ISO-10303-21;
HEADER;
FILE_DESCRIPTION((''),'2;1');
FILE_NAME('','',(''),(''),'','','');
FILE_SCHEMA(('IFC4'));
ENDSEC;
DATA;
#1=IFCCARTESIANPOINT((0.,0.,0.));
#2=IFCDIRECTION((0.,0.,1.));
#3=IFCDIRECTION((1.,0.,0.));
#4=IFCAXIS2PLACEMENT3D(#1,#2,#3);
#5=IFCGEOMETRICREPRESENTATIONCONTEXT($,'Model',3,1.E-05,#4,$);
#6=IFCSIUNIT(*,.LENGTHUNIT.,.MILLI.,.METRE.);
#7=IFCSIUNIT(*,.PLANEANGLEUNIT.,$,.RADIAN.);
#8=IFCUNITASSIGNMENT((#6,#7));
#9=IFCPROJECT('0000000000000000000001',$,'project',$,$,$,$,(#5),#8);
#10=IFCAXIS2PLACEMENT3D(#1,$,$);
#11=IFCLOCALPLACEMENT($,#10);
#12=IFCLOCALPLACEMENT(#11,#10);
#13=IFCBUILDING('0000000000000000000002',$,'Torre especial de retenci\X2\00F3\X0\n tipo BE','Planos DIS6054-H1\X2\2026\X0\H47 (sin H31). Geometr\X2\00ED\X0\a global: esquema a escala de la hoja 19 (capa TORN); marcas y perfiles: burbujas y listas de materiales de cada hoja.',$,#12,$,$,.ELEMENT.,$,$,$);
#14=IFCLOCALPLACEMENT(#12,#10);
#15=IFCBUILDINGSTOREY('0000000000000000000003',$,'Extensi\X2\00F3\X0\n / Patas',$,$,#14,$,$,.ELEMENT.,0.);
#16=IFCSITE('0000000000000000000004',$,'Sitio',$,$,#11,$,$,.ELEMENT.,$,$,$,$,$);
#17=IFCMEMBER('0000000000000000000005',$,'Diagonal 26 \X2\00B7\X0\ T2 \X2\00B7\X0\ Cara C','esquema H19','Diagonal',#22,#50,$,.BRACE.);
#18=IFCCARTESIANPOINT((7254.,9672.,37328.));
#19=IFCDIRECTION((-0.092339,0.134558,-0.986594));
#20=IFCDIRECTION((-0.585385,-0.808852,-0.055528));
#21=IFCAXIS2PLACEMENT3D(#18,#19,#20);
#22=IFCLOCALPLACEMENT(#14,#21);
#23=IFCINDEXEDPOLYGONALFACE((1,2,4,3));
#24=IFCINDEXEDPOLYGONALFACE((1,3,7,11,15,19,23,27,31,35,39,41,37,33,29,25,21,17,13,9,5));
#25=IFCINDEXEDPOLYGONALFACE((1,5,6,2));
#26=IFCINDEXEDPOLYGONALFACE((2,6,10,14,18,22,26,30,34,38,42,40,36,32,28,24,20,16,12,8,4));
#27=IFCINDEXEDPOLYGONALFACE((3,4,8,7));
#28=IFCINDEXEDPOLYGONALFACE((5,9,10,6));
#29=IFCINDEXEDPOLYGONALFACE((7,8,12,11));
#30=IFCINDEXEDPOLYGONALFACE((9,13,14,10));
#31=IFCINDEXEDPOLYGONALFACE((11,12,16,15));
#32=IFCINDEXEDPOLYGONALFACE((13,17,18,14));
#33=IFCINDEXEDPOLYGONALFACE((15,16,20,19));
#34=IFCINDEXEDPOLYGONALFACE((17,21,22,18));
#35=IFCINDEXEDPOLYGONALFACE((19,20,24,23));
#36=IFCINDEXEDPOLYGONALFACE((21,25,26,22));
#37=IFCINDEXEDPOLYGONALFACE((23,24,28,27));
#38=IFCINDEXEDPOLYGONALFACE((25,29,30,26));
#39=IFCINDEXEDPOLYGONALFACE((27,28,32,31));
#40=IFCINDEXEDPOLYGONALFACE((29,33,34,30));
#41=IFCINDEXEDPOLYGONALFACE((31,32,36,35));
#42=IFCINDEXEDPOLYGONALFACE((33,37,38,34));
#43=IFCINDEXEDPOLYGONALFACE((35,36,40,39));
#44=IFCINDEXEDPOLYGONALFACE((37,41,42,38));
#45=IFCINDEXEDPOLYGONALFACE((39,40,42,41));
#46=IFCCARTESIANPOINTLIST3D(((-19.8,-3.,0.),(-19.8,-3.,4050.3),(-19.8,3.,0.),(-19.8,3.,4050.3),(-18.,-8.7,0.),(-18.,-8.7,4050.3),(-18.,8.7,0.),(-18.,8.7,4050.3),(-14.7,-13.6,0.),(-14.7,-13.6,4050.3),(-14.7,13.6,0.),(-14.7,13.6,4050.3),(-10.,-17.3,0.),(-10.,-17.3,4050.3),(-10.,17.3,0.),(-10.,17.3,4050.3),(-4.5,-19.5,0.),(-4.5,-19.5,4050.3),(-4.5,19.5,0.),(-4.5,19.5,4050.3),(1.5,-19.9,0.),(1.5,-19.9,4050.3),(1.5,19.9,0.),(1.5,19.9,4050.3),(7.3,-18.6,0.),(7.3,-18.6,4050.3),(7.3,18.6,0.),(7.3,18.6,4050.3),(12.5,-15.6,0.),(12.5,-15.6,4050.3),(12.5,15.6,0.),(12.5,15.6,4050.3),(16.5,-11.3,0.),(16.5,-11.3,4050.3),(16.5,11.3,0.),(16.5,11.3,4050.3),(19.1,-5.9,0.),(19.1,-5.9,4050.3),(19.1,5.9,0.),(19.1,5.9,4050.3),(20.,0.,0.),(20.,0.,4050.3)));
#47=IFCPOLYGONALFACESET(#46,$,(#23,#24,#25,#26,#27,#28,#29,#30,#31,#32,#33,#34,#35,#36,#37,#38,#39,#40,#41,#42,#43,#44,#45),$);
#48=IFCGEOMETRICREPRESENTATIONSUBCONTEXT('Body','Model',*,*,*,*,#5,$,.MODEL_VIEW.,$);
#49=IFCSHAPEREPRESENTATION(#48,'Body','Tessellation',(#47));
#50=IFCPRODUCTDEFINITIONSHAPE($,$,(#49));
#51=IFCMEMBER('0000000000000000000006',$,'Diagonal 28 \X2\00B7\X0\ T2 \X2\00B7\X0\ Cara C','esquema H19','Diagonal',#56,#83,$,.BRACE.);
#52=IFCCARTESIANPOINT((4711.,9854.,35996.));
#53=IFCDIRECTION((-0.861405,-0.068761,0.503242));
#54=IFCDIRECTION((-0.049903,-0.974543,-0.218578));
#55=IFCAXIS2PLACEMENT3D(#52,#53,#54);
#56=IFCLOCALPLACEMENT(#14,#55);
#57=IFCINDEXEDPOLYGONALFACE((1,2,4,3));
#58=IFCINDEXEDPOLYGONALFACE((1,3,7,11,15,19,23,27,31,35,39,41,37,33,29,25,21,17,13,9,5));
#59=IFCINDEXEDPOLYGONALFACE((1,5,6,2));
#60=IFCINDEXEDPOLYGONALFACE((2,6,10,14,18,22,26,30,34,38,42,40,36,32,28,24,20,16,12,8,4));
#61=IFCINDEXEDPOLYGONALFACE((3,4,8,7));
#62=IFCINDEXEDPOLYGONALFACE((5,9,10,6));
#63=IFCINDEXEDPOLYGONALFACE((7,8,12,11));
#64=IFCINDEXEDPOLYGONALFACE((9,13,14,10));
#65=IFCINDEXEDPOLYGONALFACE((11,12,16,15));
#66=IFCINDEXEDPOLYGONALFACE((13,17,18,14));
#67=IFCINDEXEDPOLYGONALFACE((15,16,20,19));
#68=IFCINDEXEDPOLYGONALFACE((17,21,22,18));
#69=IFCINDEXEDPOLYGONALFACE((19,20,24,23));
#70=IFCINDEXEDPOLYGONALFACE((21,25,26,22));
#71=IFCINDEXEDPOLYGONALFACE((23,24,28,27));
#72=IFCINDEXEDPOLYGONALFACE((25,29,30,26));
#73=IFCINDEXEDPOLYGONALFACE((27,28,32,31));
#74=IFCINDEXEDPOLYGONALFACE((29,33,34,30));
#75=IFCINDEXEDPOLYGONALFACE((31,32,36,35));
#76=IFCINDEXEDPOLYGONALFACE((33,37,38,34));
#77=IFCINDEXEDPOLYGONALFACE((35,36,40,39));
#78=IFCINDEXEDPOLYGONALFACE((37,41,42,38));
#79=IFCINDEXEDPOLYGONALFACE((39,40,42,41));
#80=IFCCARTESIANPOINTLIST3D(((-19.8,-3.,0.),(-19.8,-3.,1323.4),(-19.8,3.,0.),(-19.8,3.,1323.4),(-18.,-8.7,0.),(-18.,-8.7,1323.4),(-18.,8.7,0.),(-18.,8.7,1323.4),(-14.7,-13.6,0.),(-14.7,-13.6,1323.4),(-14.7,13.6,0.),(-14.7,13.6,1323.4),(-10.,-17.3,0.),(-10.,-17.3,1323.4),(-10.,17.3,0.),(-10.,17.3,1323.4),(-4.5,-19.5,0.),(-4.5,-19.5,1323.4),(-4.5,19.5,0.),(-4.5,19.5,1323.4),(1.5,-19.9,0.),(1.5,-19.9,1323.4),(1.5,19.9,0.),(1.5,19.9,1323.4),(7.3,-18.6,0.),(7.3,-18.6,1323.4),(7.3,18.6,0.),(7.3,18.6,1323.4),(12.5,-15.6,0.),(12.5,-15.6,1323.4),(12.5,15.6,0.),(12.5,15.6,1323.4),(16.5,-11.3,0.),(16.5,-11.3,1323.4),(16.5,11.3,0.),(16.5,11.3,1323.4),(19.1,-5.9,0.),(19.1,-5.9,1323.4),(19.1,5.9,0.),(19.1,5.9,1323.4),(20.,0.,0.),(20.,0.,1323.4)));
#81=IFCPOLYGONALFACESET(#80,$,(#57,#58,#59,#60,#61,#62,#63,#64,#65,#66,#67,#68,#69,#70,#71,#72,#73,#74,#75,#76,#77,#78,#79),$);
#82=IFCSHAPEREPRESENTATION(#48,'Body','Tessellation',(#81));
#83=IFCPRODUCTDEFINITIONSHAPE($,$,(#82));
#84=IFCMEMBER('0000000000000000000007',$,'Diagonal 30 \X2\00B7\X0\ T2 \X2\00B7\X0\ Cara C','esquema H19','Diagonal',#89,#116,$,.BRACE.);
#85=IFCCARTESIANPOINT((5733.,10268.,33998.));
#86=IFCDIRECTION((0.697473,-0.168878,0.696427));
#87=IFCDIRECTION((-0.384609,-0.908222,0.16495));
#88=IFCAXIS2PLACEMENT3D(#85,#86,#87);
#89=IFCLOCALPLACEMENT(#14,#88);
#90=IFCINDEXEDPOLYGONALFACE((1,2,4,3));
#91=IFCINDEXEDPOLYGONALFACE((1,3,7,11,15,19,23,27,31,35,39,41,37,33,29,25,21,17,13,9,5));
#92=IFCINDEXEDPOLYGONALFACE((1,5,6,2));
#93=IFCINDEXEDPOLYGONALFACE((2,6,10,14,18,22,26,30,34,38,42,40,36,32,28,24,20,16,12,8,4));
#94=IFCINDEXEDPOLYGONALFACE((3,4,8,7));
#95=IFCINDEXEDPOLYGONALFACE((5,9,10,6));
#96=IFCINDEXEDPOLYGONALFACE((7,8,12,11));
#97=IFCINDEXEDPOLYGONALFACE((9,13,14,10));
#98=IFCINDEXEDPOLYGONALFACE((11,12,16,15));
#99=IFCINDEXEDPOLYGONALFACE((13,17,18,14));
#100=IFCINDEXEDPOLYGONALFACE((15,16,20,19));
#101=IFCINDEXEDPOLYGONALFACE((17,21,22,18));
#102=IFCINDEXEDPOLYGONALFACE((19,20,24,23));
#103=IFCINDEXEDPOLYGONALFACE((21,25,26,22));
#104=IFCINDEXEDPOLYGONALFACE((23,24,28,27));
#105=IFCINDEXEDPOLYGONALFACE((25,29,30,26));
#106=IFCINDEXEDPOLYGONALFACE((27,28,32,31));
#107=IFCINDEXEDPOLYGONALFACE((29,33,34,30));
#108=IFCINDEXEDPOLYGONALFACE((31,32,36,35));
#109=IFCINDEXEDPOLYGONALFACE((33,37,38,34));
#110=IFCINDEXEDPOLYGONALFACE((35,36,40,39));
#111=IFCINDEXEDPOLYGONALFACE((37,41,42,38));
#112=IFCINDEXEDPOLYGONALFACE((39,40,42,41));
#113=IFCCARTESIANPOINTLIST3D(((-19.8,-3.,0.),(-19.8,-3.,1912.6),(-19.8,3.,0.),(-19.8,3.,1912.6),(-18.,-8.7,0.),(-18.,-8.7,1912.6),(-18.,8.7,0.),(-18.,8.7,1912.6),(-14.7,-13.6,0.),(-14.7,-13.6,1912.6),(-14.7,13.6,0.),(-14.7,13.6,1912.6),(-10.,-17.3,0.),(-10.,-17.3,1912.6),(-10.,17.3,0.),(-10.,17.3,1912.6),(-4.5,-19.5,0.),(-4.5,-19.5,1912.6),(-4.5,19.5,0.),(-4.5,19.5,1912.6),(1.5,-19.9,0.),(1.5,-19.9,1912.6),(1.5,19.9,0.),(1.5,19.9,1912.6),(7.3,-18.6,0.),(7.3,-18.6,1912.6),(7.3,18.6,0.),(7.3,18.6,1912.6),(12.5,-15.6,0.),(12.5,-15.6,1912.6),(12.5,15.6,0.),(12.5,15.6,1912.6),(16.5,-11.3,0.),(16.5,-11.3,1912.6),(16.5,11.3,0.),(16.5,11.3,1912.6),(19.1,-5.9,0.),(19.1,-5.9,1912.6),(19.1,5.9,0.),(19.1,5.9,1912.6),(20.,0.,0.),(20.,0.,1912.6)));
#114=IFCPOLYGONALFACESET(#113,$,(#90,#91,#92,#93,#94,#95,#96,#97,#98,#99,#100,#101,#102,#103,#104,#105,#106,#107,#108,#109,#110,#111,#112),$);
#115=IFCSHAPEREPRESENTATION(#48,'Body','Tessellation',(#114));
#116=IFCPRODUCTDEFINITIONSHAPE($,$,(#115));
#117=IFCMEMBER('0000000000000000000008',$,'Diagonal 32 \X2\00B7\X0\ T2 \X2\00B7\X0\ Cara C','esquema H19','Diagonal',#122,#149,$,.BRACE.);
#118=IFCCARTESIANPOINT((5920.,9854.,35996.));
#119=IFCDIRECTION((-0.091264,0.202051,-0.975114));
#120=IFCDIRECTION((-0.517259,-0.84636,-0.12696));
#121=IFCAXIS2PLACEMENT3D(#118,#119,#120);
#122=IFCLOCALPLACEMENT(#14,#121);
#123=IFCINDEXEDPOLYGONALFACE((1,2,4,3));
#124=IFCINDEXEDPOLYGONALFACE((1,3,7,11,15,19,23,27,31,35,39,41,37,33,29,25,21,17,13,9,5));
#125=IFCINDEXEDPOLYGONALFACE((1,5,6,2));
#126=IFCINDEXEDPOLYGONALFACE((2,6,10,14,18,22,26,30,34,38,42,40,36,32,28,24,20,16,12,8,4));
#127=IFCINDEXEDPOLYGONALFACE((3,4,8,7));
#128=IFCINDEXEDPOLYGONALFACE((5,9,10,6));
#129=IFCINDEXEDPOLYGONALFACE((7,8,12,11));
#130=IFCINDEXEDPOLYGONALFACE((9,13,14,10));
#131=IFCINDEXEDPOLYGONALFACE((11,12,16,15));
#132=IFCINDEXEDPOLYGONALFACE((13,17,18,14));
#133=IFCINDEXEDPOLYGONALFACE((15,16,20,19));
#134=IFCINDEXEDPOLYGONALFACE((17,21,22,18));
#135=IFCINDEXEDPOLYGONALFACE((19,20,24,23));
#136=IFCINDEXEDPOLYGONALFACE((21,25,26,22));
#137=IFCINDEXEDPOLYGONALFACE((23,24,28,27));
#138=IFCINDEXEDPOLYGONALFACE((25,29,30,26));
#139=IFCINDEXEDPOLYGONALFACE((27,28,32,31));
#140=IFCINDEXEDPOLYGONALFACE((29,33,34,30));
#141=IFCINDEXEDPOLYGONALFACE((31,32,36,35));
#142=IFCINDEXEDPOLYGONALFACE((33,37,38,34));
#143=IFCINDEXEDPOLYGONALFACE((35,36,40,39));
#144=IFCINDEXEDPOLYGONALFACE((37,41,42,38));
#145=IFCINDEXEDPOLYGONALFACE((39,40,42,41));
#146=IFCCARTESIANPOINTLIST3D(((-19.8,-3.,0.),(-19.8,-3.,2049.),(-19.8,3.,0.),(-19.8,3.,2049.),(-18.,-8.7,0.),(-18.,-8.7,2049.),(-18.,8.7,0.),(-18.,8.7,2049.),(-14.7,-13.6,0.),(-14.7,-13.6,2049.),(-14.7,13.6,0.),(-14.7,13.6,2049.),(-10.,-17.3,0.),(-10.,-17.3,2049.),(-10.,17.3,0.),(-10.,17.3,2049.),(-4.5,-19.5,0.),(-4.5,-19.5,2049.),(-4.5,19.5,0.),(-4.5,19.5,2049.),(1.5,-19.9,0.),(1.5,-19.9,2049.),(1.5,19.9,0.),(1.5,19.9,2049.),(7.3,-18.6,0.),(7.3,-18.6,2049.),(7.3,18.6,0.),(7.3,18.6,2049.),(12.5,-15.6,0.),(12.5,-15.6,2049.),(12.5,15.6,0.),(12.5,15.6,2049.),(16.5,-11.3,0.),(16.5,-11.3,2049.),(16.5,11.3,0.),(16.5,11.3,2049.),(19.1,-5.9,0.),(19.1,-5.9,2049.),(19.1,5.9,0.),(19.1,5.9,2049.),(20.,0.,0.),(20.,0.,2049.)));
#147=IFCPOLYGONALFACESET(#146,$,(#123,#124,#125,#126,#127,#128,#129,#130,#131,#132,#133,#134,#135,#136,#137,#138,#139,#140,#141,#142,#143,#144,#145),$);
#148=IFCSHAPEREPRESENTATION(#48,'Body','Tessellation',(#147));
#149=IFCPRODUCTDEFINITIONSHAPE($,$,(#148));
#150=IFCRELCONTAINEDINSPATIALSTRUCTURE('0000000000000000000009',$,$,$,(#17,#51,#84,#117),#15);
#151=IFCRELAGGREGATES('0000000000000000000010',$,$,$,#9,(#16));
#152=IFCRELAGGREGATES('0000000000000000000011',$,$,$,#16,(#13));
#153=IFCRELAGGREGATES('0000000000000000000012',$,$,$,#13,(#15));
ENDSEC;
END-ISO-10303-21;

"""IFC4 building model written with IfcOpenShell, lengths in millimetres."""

from ifc_helpers import new_model, si_unit, frame, origin, origin_with_axes, place, context, subcontext, project, spatial, circle, extrude, element, save


model = new_model("IFC4")

# Units and contexts
model_context = context("Model", 3, precision=1e-05, world=origin_with_axes())
body_context = subcontext(model_context, "Body", "Model", "MODEL_VIEW")
ifc_project = project(units=[si_unit("LENGTHUNIT", "METRE", prefix="MILLI"), si_unit("PLANEANGLEUNIT", "RADIAN")], contexts=[model_context])

# Site, building, storey
site_placement = place(None, origin())
site = spatial("IfcSite", under=ifc_project, at=site_placement, Name="Sitio", CompositionType="ELEMENT")
building_placement = place(site_placement, origin())
building = spatial("IfcBuilding", under=site, at=building_placement, Name="Torre especial de retención tipo BE", Description="Planos DIS6054-H1…H47 (sin H31). Geometría global: esquema a escala de la hoja 19 (capa TORN); marcas y perfiles: burbujas y listas de materiales de cada hoja.", CompositionType="ELEMENT")
storey_placement = place(building_placement, origin())
storey = spatial("IfcBuildingStorey", under=building, at=storey_placement, Name="Extensión / Patas", CompositionType="ELEMENT", Elevation=0.0)

# Members
member_1_placement = place(storey_placement, frame((7254.0, 9672.0, 37328.0), z_axis=(-0.092339, 0.134558, -0.986594), x_axis=(-0.585385, -0.808852, -0.055528)))
element("IfcMember", 1, at=member_1_placement, inside=storey, Name="Diagonal 26 · T2 · Cara C", Description="esquema H19", ObjectType="Diagonal", PredefinedType="BRACE", context=body_context, shape_type="SweptSolid", body=[
    extrude(circle(Radius=20.0), None, (0.0, 0.0, 1.0), 4050.3),
])
member_2_placement = place(storey_placement, frame((4711.0, 9854.0, 35996.0), z_axis=(-0.861405, -0.068761, 0.503242), x_axis=(-0.049903, -0.974543, -0.218578)))
element("IfcMember", 2, at=member_2_placement, inside=storey, Name="Diagonal 28 · T2 · Cara C", Description="esquema H19", ObjectType="Diagonal", PredefinedType="BRACE", context=body_context, shape_type="SweptSolid", body=[
    extrude(circle(Radius=20.0), None, (0.0, 0.0, 1.0), 1323.4),
])
member_3_placement = place(storey_placement, frame((5733.0, 10268.0, 33998.0), z_axis=(0.697473, -0.168878, 0.696427), x_axis=(-0.384609, -0.908222, 0.16495)))
element("IfcMember", 3, at=member_3_placement, inside=storey, Name="Diagonal 30 · T2 · Cara C", Description="esquema H19", ObjectType="Diagonal", PredefinedType="BRACE", context=body_context, shape_type="SweptSolid", body=[
    extrude(circle(Radius=20.0), None, (0.0, 0.0, 1.0), 1912.6),
])
member_4_placement = place(storey_placement, frame((5920.0, 9854.0, 35996.0), z_axis=(-0.091264, 0.202051, -0.975114), x_axis=(-0.517259, -0.84636, -0.12696)))
element("IfcMember", 4, at=member_4_placement, inside=storey, Name="Diagonal 32 · T2 · Cara C", Description="esquema H19", ObjectType="Diagonal", PredefinedType="BRACE", context=body_context, shape_type="SweptSolid", body=[
    extrude(circle(Radius=20.0), None, (0.0, 0.0, 1.0), 2049.0),
])

save(model, "model.ifc")
